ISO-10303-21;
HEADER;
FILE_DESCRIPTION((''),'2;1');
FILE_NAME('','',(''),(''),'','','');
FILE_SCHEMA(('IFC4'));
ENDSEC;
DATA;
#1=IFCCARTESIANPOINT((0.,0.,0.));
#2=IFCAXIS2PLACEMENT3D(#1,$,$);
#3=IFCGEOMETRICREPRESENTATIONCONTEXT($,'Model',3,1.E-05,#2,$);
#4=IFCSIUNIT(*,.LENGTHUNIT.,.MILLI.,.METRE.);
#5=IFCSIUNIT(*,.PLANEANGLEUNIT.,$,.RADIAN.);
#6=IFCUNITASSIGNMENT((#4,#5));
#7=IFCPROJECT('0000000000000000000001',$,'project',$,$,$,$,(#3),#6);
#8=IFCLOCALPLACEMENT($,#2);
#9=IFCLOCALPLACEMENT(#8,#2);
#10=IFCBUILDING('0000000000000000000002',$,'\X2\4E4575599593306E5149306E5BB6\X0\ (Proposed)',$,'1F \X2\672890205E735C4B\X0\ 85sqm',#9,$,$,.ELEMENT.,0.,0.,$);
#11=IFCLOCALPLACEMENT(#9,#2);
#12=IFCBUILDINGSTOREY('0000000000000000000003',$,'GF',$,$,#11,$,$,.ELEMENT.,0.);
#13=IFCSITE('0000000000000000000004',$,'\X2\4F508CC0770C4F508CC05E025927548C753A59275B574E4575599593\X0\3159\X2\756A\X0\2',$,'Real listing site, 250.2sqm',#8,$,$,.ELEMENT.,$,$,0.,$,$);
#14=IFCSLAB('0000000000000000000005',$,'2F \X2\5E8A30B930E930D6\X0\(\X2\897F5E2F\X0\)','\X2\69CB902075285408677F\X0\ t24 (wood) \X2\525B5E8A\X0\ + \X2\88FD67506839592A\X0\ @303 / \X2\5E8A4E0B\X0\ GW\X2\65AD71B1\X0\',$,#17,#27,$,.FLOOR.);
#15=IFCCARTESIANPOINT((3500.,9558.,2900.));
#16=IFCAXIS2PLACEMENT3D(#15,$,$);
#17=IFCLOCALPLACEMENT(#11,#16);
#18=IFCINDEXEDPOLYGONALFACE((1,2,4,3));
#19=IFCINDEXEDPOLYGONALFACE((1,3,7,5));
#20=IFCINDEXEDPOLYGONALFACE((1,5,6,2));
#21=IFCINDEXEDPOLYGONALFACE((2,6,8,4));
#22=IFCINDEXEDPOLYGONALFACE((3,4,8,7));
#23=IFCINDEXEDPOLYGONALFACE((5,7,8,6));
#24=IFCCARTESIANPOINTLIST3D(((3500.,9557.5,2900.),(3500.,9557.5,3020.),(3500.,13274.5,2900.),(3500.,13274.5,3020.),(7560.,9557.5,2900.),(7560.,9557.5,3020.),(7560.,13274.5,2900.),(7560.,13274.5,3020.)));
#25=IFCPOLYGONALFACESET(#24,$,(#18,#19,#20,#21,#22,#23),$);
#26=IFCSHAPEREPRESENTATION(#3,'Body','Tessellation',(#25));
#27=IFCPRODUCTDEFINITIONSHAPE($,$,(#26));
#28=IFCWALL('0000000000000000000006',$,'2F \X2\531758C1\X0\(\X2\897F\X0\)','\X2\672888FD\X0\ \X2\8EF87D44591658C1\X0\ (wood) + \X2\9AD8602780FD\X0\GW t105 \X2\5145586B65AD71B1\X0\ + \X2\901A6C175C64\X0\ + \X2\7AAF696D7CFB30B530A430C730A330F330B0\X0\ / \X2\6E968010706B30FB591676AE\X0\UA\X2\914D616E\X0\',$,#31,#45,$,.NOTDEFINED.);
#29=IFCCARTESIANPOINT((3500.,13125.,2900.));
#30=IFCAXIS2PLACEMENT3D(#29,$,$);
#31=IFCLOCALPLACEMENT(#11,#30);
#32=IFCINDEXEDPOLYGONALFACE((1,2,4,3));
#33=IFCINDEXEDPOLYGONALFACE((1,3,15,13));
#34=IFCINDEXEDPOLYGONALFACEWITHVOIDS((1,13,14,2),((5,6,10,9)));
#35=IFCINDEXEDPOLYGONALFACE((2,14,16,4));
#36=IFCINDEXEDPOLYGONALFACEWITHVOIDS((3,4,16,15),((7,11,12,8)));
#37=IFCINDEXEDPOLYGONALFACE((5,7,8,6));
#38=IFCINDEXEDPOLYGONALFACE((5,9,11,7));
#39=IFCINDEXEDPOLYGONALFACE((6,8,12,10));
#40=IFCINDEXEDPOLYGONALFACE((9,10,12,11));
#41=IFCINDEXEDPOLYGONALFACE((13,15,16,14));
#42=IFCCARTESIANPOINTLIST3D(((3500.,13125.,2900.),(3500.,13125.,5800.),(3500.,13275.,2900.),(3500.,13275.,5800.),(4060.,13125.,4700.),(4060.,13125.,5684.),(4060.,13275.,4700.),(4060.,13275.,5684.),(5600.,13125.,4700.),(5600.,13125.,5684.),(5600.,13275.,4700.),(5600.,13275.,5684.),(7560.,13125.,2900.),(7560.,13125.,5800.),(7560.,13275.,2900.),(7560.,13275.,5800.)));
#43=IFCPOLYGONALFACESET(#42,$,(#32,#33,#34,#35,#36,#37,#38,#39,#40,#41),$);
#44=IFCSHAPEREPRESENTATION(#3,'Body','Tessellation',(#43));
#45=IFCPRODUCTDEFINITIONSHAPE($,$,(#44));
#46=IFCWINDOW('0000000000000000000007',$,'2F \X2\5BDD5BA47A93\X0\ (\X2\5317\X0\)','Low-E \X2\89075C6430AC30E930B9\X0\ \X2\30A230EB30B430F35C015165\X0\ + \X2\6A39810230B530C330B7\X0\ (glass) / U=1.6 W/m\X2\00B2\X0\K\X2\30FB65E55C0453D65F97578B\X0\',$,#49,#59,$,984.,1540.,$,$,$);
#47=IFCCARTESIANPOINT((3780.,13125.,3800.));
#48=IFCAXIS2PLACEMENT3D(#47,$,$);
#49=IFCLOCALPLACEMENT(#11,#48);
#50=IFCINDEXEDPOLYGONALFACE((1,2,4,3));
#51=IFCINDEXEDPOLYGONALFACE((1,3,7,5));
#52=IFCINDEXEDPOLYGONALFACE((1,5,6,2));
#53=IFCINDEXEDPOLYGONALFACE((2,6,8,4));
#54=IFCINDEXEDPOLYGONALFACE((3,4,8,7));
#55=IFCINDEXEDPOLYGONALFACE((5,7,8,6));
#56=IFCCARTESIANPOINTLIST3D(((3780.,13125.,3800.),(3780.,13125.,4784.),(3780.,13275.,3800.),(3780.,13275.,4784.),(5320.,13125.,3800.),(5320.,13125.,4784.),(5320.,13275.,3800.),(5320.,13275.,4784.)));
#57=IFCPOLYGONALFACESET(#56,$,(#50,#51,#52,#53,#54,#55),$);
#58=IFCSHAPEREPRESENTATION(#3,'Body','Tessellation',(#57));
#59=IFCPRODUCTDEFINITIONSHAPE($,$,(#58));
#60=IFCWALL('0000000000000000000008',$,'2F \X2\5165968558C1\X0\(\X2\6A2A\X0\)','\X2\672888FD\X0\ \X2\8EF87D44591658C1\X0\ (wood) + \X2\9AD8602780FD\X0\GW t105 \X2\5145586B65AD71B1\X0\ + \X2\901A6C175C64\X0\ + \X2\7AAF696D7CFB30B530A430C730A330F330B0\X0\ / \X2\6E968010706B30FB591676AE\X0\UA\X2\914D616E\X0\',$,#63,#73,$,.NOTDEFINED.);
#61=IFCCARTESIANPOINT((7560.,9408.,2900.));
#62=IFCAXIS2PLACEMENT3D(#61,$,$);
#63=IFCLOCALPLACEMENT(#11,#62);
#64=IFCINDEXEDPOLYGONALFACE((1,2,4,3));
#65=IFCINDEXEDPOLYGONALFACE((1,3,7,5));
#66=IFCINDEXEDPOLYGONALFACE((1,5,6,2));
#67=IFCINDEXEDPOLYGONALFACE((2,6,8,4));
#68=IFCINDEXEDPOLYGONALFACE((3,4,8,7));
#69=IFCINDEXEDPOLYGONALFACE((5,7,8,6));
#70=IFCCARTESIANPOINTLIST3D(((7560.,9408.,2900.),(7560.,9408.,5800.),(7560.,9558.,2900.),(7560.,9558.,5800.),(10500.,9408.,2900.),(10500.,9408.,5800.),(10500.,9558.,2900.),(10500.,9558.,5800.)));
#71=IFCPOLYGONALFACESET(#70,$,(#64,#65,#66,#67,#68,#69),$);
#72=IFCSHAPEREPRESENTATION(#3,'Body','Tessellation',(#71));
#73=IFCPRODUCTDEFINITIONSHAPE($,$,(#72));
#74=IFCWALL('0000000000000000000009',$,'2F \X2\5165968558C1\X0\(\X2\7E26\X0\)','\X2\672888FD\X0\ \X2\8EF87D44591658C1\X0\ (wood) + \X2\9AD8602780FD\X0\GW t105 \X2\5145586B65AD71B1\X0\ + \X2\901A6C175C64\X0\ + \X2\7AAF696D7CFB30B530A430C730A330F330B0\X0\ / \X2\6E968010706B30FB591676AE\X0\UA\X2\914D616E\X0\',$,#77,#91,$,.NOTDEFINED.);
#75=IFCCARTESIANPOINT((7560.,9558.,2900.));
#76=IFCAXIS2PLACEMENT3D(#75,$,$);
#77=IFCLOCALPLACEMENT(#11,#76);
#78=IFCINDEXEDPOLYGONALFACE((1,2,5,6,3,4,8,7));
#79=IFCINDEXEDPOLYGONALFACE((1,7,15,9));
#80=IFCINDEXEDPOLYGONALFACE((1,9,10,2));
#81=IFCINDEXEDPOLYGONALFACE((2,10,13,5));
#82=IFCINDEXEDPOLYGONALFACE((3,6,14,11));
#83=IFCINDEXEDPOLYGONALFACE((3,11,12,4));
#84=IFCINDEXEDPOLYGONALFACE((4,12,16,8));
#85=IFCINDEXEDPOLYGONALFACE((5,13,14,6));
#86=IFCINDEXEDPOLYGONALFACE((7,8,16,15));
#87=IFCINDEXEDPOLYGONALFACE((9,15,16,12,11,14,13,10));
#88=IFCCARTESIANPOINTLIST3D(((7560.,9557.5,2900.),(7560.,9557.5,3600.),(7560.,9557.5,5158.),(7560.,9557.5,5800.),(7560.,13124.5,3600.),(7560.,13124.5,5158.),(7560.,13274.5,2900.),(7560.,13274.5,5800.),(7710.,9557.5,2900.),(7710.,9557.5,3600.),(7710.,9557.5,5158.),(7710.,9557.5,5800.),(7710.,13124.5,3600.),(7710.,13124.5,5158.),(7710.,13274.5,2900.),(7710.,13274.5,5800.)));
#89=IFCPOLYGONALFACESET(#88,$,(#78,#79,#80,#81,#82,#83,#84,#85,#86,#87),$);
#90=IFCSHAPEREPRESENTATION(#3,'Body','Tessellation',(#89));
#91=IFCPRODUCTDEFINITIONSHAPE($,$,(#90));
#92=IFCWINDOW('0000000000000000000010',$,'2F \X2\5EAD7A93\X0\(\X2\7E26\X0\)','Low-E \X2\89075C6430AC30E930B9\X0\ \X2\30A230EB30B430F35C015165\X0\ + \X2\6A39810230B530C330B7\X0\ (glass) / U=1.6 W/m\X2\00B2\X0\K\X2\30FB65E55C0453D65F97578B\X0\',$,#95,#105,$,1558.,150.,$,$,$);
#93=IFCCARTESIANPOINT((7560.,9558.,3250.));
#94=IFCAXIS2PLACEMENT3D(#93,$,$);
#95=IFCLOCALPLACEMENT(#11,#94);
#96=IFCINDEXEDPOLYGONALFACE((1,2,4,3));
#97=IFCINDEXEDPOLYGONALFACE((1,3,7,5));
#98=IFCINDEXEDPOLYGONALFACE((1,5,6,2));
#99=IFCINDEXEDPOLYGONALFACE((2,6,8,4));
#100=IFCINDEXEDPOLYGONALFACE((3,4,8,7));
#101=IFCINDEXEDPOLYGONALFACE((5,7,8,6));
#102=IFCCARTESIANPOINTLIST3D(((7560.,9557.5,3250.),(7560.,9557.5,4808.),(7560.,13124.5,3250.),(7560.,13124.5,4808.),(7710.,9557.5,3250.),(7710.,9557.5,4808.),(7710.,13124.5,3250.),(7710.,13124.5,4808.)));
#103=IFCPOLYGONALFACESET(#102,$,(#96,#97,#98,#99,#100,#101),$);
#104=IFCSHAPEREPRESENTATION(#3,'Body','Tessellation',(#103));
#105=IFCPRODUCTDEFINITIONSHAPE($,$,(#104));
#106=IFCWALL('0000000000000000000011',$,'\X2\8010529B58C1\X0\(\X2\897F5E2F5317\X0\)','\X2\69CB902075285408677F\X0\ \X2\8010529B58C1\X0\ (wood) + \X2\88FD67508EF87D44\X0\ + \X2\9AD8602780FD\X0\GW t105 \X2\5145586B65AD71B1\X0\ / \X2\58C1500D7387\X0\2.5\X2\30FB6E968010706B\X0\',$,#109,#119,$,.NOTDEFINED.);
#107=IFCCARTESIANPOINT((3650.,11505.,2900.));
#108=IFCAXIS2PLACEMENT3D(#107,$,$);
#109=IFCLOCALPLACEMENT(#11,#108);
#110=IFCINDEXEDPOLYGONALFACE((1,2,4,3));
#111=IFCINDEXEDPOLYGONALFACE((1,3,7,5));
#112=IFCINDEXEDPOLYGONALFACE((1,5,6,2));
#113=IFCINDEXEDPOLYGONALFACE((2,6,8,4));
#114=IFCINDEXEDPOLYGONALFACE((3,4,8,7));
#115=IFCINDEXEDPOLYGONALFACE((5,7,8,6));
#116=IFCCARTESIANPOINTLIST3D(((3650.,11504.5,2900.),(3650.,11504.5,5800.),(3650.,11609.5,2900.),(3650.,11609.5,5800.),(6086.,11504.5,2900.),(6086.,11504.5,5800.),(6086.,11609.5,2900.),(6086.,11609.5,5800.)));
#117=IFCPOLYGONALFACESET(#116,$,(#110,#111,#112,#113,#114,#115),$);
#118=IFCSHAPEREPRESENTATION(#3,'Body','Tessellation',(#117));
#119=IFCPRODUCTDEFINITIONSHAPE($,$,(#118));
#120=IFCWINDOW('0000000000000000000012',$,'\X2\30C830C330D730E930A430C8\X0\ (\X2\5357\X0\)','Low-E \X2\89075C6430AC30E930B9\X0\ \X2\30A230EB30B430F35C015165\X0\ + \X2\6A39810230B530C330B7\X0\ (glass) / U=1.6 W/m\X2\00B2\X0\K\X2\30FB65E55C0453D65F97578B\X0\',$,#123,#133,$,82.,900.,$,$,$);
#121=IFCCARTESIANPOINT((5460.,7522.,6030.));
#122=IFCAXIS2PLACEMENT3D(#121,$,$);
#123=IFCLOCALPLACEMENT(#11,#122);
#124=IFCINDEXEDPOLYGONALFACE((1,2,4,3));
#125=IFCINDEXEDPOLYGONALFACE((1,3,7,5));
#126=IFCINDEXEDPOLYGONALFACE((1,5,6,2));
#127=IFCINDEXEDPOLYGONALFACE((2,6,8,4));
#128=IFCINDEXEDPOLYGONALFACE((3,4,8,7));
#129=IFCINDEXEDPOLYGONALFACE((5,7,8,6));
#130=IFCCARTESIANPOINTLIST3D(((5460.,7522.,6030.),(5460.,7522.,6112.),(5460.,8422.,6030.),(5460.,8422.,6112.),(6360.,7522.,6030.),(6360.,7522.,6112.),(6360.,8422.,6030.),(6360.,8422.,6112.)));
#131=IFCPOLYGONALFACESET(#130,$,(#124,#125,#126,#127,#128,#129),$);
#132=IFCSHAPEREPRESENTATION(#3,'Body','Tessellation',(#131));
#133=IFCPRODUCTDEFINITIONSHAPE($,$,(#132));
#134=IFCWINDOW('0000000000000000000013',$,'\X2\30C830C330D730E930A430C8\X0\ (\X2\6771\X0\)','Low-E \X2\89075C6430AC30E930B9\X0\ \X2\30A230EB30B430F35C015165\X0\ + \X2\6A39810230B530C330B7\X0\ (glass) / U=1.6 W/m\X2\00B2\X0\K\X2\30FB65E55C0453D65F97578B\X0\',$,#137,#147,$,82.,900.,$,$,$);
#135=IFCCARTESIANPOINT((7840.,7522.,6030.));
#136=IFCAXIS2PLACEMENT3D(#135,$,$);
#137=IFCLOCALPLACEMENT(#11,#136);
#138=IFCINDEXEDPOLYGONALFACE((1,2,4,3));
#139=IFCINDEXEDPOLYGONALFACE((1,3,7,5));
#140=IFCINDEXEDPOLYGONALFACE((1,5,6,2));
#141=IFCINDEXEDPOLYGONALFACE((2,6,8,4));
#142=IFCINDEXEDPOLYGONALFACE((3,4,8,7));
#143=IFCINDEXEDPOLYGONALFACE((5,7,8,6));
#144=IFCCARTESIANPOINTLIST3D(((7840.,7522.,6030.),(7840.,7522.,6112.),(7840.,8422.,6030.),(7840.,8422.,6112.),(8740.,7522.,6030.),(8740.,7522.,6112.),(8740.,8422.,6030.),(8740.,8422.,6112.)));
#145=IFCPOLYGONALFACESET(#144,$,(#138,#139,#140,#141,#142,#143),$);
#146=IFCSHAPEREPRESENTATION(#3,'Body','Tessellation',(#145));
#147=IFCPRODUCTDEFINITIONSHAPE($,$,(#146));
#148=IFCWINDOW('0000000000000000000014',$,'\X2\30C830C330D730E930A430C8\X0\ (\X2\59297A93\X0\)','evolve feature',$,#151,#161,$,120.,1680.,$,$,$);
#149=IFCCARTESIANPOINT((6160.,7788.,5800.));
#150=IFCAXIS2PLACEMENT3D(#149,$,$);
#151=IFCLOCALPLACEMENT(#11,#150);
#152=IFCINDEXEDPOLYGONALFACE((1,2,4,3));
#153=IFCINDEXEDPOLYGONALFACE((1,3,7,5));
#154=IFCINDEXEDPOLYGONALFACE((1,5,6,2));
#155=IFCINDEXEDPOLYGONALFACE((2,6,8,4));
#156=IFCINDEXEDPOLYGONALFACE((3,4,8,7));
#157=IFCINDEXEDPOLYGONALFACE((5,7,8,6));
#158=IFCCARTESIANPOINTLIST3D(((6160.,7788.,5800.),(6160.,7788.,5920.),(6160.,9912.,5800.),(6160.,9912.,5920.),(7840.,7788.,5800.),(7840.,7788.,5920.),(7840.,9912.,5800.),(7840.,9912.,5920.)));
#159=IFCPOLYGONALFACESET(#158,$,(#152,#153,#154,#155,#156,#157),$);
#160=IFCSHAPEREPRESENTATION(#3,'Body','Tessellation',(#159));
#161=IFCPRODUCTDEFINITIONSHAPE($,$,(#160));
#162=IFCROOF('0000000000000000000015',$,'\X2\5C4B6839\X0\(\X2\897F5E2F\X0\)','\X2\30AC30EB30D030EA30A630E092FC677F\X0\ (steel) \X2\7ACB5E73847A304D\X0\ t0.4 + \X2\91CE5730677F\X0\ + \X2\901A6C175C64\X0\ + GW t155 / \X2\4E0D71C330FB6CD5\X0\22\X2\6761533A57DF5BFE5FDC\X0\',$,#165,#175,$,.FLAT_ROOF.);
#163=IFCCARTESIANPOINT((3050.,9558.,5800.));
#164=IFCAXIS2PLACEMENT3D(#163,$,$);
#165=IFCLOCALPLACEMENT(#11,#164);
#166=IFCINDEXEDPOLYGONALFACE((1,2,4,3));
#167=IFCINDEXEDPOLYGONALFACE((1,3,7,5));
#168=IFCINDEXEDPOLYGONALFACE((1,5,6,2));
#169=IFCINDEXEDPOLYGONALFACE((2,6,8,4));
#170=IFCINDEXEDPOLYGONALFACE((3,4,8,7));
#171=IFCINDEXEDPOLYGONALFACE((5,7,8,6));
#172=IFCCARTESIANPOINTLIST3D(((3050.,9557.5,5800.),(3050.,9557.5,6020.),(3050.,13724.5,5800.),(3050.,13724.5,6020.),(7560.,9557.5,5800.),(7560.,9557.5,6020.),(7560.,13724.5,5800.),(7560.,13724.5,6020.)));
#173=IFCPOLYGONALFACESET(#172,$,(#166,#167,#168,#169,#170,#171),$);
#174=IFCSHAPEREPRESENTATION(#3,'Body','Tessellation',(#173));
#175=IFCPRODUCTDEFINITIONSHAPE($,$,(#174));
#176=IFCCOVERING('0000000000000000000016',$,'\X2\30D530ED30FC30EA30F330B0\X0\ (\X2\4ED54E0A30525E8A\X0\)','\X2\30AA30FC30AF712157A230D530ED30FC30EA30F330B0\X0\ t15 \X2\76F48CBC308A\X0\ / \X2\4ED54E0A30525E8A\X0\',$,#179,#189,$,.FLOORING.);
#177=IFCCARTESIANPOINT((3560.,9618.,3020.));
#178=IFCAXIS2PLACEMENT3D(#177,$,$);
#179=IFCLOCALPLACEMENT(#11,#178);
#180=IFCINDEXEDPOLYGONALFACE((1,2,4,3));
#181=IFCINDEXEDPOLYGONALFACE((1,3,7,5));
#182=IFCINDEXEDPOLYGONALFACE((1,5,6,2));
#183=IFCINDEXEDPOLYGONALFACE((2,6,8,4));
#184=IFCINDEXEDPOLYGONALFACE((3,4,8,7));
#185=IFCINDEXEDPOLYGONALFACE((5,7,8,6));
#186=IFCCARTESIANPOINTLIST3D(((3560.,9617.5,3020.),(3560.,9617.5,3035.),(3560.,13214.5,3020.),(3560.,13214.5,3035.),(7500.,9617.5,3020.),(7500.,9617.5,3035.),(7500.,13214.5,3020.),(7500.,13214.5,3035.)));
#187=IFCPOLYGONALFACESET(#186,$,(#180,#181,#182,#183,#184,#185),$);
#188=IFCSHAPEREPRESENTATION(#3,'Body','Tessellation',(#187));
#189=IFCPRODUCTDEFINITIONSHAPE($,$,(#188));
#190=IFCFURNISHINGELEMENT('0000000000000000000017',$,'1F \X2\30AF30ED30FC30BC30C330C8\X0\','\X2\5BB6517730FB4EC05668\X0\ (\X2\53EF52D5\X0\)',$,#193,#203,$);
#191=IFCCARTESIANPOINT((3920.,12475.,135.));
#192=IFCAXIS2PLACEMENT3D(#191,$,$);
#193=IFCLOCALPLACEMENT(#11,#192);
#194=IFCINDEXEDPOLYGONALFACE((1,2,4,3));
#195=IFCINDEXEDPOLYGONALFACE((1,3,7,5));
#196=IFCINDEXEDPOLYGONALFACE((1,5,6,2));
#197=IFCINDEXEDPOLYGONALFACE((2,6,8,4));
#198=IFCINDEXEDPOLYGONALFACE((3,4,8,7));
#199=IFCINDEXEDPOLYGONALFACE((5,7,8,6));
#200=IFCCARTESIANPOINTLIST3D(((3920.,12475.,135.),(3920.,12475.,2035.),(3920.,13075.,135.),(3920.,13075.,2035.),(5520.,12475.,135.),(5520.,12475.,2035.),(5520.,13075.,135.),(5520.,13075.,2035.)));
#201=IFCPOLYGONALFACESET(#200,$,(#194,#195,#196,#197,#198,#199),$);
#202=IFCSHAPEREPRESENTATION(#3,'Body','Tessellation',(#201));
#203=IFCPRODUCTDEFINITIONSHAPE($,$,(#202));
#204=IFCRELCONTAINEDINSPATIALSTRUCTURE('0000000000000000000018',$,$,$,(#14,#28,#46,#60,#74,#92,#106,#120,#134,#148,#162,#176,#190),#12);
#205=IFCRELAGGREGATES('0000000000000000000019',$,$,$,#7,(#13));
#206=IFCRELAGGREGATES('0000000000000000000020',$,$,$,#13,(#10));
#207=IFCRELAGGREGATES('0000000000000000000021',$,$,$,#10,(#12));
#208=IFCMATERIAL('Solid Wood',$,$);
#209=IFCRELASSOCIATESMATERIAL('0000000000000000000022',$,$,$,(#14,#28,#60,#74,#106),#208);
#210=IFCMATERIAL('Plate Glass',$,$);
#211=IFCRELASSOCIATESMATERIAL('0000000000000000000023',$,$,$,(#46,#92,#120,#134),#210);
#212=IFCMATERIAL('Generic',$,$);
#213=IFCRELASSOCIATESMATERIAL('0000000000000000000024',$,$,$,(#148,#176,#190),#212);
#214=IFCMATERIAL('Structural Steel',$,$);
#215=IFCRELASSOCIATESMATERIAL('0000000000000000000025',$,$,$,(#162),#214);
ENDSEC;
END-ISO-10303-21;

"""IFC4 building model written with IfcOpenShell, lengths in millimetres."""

from ifc_helpers import new_model, si_unit, frame, frame_2d, origin, place, context, project, spatial, rectangle, extrude, material, element, fill, save


model = new_model("IFC4")

# Units and contexts
model_context = context("Model", 3, precision=1e-05, world=origin())
ifc_project = project(units=[si_unit("LENGTHUNIT", "METRE", prefix="MILLI"), si_unit("PLANEANGLEUNIT", "RADIAN")], contexts=[model_context])

# Site, building, storey
site_placement = place(None, origin())
site = spatial("IfcSite", under=ifc_project, at=site_placement, Name="佐賀県佐賀市大和町大字久留間3159番2", ObjectType="Real listing site, 250.2sqm", CompositionType="ELEMENT", RefElevation=0.0)
building_placement = place(site_placement, origin())
building = spatial("IfcBuilding", under=site, at=building_placement, Name="久留間の光の家 (Proposed)", ObjectType="1F 木造平屋 85sqm", CompositionType="ELEMENT", ElevationOfRefHeight=0.0, ElevationOfTerrain=0.0)
storey_placement = place(building_placement, origin())
storey = spatial("IfcBuildingStorey", under=building, at=storey_placement, Name="GF", CompositionType="ELEMENT", Elevation=0.0)

# Slab
ifc_material_1 = material(Name="Solid Wood")
slab_placement = place(storey_placement, frame((3500.0, 9558.0, 2900.0)))
element("IfcSlab", 1, at=slab_placement, inside=storey, material=ifc_material_1, Name="2F 床スラブ(西帯)", Description="構造用合板 t24 (wood) 剛床 + 製材根太 @303 / 床下 GW断熱", PredefinedType="FLOOR", context=model_context, shape_type="SweptSolid", body=[
    extrude(rectangle(XDim=4060.0, YDim=3717.0, at=frame_2d((2030.0, 1858.0))), frame((3500.0, 9558.0, 2900.0)), (0.0, 0.0, 1.0), 120.0),
])

# Wall, opening, window
wall_1_placement = place(storey_placement, frame((3500.0, 13125.0, 2900.0)))
wall_1 = element("IfcWall", 2, at=wall_1_placement, inside=storey, material=ifc_material_1, Name="2F 北壁(西)", Description="木製 軸組外壁 (wood) + 高性能GW t105 充填断熱 + 通気層 + 窯業系サイディング / 準耐火・外皮UA配慮", PredefinedType="NOTDEFINED", context=model_context, shape_type="SweptSolid", body=[
    extrude(rectangle(XDim=4060.0, YDim=150.0, at=frame_2d((2030.0, 75.0))), frame((3500.0, 13125.0, 2900.0)), (0.0, 0.0, 1.0), 2900.0),
])
opening_1_placement = place(storey_placement, frame((3780.0, 13125.0, 3800.0)))
opening_1 = element("IfcOpeningElement", 3, at=opening_1_placement, cuts=wall_1, PredefinedType="NOTDEFINED", context=model_context, shape_type="SweptSolid", body=[
    extrude(rectangle(XDim=1540.0, YDim=150.0, at=frame_2d((770.0, 75.0))), frame((3780.0, 13125.0, 3800.0)), (0.0, 0.0, 1.0), 984.0),
])
ifc_material_2 = material(Name="Plate Glass")
window_1_placement = place(storey_placement, frame((3780.0, 13125.0, 3800.0)))
window_1 = element("IfcWindow", 4, at=window_1_placement, inside=storey, material=ifc_material_2, Name="2F 寝室窓 (北)", Description="Low-E 複層ガラス アルゴン封入 + 樹脂サッシ (glass) / U=1.6 W/m²K・日射取得型", OverallHeight=984.0, OverallWidth=1540.0, context=model_context, shape_type="SweptSolid", body=[
    extrude(rectangle(XDim=1540.0, YDim=150.0, at=frame_2d((770.0, 75.0))), frame((3780.0, 13125.0, 3800.0)), (0.0, 0.0, 1.0), 984.0),
])
fill(opening_1, window_1)

# Wall
wall_2_placement = place(storey_placement, frame((7560.0, 9408.0, 2900.0)))
element("IfcWall", 5, at=wall_2_placement, inside=storey, material=ifc_material_1, Name="2F 入隅壁(横)", Description="木製 軸組外壁 (wood) + 高性能GW t105 充填断熱 + 通気層 + 窯業系サイディング / 準耐火・外皮UA配慮", PredefinedType="NOTDEFINED", context=model_context, shape_type="SweptSolid", body=[
    extrude(rectangle(XDim=2940.0, YDim=150.0, at=frame_2d((1470.0, 75.0))), frame((7560.0, 9408.0, 2900.0)), (0.0, 0.0, 1.0), 2900.0),
])

# Wall, opening, window
wall_3_placement = place(storey_placement, frame((7560.0, 9558.0, 2900.0)))
wall_3 = element("IfcWall", 6, at=wall_3_placement, inside=storey, material=ifc_material_1, Name="2F 入隅壁(縦)", Description="木製 軸組外壁 (wood) + 高性能GW t105 充填断熱 + 通気層 + 窯業系サイディング / 準耐火・外皮UA配慮", PredefinedType="NOTDEFINED", context=model_context, shape_type="SweptSolid", body=[
    extrude(rectangle(XDim=150.0, YDim=3717.0, at=frame_2d((75.0, 1858.0))), frame((7560.0, 9558.0, 2900.0)), (0.0, 0.0, 1.0), 2900.0),
])
opening_2_placement = place(storey_placement, frame((7560.0, 9558.0, 3250.0)))
opening_2 = element("IfcOpeningElement", 7, at=opening_2_placement, cuts=wall_3, PredefinedType="NOTDEFINED", context=model_context, shape_type="SweptSolid", body=[
    extrude(rectangle(XDim=150.0, YDim=3567.0, at=frame_2d((75.0, 1783.0))), frame((7560.0, 9558.0, 3250.0)), (0.0, 0.0, 1.0), 1558.0),
])
window_2_placement = place(storey_placement, frame((7560.0, 9558.0, 3250.0)))
window_2 = element("IfcWindow", 8, at=window_2_placement, inside=storey, material=ifc_material_2, Name="2F 庭窓(縦)", Description="Low-E 複層ガラス アルゴン封入 + 樹脂サッシ (glass) / U=1.6 W/m²K・日射取得型", OverallHeight=1558.0, OverallWidth=150.0, context=model_context, shape_type="SweptSolid", body=[
    extrude(rectangle(XDim=150.0, YDim=3567.0, at=frame_2d((75.0, 1783.0))), frame((7560.0, 9558.0, 3250.0)), (0.0, 0.0, 1.0), 1558.0),
])
fill(opening_2, window_2)

# Wall
wall_4_placement = place(storey_placement, frame((3650.0, 11505.0, 2900.0)))
element("IfcWall", 9, at=wall_4_placement, inside=storey, material=ifc_material_1, Name="耐力壁(西帯北)", Description="構造用合板 耐力壁 (wood) + 製材軸組 + 高性能GW t105 充填断熱 / 壁倍率2.5・準耐火", PredefinedType="NOTDEFINED", context=model_context, shape_type="SweptSolid", body=[
    extrude(rectangle(XDim=2436.0, YDim=105.0, at=frame_2d((1218.0, 52.0))), frame((3650.0, 11505.0, 2900.0)), (0.0, 0.0, 1.0), 2900.0),
])

# Windows
window_3_placement = place(storey_placement, frame((5460.0, 7522.0, 6030.0)))
element("IfcWindow", 10, at=window_3_placement, inside=storey, material=ifc_material_2, Name="トップライト (南)", Description="Low-E 複層ガラス アルゴン封入 + 樹脂サッシ (glass) / U=1.6 W/m²K・日射取得型", OverallHeight=82.0, OverallWidth=900.0, context=model_context, shape_type="SweptSolid", body=[
    extrude(rectangle(XDim=900.0, YDim=900.0, at=frame_2d((450.0, 450.0))), frame((5460.0, 7522.0, 6030.0)), (0.0, 0.0, 1.0), 82.0),
])
window_4_placement = place(storey_placement, frame((7840.0, 7522.0, 6030.0)))
element("IfcWindow", 11, at=window_4_placement, inside=storey, material=ifc_material_2, Name="トップライト (東)", Description="Low-E 複層ガラス アルゴン封入 + 樹脂サッシ (glass) / U=1.6 W/m²K・日射取得型", OverallHeight=82.0, OverallWidth=900.0, context=model_context, shape_type="SweptSolid", body=[
    extrude(rectangle(XDim=900.0, YDim=900.0, at=frame_2d((450.0, 450.0))), frame((7840.0, 7522.0, 6030.0)), (0.0, 0.0, 1.0), 82.0),
])
ifc_material_3 = material(Name="Generic")
window_5_placement = place(storey_placement, frame((6160.0, 7788.0, 5800.0)))
element("IfcWindow", 12, at=window_5_placement, inside=storey, material=ifc_material_3, Name="トップライト (天窓)", Description="evolve feature", OverallHeight=120.0, OverallWidth=1680.0, context=model_context, shape_type="SweptSolid", body=[
    extrude(rectangle(XDim=1680.0, YDim=2124.0, at=frame_2d((840.0, 1062.0))), frame((6160.0, 7788.0, 5800.0)), (0.0, 0.0, 1.0), 120.0),
])

# Roof
ifc_material_4 = material(Name="Structural Steel")
for number, where, name in (
    (13, (3050.0, 9558.0, 5800.0), "屋根(西帯)"),
):
    element("IfcRoof", number, at=place(storey_placement, frame(where)), inside=storey, material=ifc_material_4, Name=name, Description="ガルバリウム鋼板 (steel) 立平葺き t0.4 + 野地板 + 通気層 + GW t155 / 不燃・法22条区域対応", PredefinedType="FLAT_ROOF", context=model_context, shape_type="SweptSolid", body=[
        extrude(rectangle(XDim=4510.0, YDim=4167.0, at=frame_2d((2255.0, 2083.0))), frame((3050.0, 9558.0, 5800.0)), (0.0, 0.0, 1.0), 220.0),
    ])

# Covering
covering_placement = place(storey_placement, frame((3560.0, 9618.0, 3020.0)))
element("IfcCovering", 14, at=covering_placement, inside=storey, material=ifc_material_3, Name="フローリング (仕上げ床)", Description="オーク無垢フローリング t15 直貼り / 仕上げ床", PredefinedType="FLOORING", context=model_context, shape_type="SweptSolid", body=[
    extrude(rectangle(XDim=3940.0, YDim=3597.0, at=frame_2d((1970.0, 1798.0))), frame((3560.0, 9618.0, 3020.0)), (0.0, 0.0, 1.0), 15.0),
])

# Furnishing element
furnishing_1_placement = place(storey_placement, frame((3920.0, 12475.0, 135.0)))
element("IfcFurnishingElement", 15, at=furnishing_1_placement, inside=storey, material=ifc_material_3, Name="1F クローゼット", Description="家具・什器 (可動)", context=model_context, shape_type="SweptSolid", body=[
    extrude(rectangle(XDim=1600.0, YDim=600.0, at=frame_2d((800.0, 300.0))), frame((3920.0, 12475.0, 135.0)), (0.0, 0.0, 1.0), 1900.0),
])

save(model, "model.ifc")
